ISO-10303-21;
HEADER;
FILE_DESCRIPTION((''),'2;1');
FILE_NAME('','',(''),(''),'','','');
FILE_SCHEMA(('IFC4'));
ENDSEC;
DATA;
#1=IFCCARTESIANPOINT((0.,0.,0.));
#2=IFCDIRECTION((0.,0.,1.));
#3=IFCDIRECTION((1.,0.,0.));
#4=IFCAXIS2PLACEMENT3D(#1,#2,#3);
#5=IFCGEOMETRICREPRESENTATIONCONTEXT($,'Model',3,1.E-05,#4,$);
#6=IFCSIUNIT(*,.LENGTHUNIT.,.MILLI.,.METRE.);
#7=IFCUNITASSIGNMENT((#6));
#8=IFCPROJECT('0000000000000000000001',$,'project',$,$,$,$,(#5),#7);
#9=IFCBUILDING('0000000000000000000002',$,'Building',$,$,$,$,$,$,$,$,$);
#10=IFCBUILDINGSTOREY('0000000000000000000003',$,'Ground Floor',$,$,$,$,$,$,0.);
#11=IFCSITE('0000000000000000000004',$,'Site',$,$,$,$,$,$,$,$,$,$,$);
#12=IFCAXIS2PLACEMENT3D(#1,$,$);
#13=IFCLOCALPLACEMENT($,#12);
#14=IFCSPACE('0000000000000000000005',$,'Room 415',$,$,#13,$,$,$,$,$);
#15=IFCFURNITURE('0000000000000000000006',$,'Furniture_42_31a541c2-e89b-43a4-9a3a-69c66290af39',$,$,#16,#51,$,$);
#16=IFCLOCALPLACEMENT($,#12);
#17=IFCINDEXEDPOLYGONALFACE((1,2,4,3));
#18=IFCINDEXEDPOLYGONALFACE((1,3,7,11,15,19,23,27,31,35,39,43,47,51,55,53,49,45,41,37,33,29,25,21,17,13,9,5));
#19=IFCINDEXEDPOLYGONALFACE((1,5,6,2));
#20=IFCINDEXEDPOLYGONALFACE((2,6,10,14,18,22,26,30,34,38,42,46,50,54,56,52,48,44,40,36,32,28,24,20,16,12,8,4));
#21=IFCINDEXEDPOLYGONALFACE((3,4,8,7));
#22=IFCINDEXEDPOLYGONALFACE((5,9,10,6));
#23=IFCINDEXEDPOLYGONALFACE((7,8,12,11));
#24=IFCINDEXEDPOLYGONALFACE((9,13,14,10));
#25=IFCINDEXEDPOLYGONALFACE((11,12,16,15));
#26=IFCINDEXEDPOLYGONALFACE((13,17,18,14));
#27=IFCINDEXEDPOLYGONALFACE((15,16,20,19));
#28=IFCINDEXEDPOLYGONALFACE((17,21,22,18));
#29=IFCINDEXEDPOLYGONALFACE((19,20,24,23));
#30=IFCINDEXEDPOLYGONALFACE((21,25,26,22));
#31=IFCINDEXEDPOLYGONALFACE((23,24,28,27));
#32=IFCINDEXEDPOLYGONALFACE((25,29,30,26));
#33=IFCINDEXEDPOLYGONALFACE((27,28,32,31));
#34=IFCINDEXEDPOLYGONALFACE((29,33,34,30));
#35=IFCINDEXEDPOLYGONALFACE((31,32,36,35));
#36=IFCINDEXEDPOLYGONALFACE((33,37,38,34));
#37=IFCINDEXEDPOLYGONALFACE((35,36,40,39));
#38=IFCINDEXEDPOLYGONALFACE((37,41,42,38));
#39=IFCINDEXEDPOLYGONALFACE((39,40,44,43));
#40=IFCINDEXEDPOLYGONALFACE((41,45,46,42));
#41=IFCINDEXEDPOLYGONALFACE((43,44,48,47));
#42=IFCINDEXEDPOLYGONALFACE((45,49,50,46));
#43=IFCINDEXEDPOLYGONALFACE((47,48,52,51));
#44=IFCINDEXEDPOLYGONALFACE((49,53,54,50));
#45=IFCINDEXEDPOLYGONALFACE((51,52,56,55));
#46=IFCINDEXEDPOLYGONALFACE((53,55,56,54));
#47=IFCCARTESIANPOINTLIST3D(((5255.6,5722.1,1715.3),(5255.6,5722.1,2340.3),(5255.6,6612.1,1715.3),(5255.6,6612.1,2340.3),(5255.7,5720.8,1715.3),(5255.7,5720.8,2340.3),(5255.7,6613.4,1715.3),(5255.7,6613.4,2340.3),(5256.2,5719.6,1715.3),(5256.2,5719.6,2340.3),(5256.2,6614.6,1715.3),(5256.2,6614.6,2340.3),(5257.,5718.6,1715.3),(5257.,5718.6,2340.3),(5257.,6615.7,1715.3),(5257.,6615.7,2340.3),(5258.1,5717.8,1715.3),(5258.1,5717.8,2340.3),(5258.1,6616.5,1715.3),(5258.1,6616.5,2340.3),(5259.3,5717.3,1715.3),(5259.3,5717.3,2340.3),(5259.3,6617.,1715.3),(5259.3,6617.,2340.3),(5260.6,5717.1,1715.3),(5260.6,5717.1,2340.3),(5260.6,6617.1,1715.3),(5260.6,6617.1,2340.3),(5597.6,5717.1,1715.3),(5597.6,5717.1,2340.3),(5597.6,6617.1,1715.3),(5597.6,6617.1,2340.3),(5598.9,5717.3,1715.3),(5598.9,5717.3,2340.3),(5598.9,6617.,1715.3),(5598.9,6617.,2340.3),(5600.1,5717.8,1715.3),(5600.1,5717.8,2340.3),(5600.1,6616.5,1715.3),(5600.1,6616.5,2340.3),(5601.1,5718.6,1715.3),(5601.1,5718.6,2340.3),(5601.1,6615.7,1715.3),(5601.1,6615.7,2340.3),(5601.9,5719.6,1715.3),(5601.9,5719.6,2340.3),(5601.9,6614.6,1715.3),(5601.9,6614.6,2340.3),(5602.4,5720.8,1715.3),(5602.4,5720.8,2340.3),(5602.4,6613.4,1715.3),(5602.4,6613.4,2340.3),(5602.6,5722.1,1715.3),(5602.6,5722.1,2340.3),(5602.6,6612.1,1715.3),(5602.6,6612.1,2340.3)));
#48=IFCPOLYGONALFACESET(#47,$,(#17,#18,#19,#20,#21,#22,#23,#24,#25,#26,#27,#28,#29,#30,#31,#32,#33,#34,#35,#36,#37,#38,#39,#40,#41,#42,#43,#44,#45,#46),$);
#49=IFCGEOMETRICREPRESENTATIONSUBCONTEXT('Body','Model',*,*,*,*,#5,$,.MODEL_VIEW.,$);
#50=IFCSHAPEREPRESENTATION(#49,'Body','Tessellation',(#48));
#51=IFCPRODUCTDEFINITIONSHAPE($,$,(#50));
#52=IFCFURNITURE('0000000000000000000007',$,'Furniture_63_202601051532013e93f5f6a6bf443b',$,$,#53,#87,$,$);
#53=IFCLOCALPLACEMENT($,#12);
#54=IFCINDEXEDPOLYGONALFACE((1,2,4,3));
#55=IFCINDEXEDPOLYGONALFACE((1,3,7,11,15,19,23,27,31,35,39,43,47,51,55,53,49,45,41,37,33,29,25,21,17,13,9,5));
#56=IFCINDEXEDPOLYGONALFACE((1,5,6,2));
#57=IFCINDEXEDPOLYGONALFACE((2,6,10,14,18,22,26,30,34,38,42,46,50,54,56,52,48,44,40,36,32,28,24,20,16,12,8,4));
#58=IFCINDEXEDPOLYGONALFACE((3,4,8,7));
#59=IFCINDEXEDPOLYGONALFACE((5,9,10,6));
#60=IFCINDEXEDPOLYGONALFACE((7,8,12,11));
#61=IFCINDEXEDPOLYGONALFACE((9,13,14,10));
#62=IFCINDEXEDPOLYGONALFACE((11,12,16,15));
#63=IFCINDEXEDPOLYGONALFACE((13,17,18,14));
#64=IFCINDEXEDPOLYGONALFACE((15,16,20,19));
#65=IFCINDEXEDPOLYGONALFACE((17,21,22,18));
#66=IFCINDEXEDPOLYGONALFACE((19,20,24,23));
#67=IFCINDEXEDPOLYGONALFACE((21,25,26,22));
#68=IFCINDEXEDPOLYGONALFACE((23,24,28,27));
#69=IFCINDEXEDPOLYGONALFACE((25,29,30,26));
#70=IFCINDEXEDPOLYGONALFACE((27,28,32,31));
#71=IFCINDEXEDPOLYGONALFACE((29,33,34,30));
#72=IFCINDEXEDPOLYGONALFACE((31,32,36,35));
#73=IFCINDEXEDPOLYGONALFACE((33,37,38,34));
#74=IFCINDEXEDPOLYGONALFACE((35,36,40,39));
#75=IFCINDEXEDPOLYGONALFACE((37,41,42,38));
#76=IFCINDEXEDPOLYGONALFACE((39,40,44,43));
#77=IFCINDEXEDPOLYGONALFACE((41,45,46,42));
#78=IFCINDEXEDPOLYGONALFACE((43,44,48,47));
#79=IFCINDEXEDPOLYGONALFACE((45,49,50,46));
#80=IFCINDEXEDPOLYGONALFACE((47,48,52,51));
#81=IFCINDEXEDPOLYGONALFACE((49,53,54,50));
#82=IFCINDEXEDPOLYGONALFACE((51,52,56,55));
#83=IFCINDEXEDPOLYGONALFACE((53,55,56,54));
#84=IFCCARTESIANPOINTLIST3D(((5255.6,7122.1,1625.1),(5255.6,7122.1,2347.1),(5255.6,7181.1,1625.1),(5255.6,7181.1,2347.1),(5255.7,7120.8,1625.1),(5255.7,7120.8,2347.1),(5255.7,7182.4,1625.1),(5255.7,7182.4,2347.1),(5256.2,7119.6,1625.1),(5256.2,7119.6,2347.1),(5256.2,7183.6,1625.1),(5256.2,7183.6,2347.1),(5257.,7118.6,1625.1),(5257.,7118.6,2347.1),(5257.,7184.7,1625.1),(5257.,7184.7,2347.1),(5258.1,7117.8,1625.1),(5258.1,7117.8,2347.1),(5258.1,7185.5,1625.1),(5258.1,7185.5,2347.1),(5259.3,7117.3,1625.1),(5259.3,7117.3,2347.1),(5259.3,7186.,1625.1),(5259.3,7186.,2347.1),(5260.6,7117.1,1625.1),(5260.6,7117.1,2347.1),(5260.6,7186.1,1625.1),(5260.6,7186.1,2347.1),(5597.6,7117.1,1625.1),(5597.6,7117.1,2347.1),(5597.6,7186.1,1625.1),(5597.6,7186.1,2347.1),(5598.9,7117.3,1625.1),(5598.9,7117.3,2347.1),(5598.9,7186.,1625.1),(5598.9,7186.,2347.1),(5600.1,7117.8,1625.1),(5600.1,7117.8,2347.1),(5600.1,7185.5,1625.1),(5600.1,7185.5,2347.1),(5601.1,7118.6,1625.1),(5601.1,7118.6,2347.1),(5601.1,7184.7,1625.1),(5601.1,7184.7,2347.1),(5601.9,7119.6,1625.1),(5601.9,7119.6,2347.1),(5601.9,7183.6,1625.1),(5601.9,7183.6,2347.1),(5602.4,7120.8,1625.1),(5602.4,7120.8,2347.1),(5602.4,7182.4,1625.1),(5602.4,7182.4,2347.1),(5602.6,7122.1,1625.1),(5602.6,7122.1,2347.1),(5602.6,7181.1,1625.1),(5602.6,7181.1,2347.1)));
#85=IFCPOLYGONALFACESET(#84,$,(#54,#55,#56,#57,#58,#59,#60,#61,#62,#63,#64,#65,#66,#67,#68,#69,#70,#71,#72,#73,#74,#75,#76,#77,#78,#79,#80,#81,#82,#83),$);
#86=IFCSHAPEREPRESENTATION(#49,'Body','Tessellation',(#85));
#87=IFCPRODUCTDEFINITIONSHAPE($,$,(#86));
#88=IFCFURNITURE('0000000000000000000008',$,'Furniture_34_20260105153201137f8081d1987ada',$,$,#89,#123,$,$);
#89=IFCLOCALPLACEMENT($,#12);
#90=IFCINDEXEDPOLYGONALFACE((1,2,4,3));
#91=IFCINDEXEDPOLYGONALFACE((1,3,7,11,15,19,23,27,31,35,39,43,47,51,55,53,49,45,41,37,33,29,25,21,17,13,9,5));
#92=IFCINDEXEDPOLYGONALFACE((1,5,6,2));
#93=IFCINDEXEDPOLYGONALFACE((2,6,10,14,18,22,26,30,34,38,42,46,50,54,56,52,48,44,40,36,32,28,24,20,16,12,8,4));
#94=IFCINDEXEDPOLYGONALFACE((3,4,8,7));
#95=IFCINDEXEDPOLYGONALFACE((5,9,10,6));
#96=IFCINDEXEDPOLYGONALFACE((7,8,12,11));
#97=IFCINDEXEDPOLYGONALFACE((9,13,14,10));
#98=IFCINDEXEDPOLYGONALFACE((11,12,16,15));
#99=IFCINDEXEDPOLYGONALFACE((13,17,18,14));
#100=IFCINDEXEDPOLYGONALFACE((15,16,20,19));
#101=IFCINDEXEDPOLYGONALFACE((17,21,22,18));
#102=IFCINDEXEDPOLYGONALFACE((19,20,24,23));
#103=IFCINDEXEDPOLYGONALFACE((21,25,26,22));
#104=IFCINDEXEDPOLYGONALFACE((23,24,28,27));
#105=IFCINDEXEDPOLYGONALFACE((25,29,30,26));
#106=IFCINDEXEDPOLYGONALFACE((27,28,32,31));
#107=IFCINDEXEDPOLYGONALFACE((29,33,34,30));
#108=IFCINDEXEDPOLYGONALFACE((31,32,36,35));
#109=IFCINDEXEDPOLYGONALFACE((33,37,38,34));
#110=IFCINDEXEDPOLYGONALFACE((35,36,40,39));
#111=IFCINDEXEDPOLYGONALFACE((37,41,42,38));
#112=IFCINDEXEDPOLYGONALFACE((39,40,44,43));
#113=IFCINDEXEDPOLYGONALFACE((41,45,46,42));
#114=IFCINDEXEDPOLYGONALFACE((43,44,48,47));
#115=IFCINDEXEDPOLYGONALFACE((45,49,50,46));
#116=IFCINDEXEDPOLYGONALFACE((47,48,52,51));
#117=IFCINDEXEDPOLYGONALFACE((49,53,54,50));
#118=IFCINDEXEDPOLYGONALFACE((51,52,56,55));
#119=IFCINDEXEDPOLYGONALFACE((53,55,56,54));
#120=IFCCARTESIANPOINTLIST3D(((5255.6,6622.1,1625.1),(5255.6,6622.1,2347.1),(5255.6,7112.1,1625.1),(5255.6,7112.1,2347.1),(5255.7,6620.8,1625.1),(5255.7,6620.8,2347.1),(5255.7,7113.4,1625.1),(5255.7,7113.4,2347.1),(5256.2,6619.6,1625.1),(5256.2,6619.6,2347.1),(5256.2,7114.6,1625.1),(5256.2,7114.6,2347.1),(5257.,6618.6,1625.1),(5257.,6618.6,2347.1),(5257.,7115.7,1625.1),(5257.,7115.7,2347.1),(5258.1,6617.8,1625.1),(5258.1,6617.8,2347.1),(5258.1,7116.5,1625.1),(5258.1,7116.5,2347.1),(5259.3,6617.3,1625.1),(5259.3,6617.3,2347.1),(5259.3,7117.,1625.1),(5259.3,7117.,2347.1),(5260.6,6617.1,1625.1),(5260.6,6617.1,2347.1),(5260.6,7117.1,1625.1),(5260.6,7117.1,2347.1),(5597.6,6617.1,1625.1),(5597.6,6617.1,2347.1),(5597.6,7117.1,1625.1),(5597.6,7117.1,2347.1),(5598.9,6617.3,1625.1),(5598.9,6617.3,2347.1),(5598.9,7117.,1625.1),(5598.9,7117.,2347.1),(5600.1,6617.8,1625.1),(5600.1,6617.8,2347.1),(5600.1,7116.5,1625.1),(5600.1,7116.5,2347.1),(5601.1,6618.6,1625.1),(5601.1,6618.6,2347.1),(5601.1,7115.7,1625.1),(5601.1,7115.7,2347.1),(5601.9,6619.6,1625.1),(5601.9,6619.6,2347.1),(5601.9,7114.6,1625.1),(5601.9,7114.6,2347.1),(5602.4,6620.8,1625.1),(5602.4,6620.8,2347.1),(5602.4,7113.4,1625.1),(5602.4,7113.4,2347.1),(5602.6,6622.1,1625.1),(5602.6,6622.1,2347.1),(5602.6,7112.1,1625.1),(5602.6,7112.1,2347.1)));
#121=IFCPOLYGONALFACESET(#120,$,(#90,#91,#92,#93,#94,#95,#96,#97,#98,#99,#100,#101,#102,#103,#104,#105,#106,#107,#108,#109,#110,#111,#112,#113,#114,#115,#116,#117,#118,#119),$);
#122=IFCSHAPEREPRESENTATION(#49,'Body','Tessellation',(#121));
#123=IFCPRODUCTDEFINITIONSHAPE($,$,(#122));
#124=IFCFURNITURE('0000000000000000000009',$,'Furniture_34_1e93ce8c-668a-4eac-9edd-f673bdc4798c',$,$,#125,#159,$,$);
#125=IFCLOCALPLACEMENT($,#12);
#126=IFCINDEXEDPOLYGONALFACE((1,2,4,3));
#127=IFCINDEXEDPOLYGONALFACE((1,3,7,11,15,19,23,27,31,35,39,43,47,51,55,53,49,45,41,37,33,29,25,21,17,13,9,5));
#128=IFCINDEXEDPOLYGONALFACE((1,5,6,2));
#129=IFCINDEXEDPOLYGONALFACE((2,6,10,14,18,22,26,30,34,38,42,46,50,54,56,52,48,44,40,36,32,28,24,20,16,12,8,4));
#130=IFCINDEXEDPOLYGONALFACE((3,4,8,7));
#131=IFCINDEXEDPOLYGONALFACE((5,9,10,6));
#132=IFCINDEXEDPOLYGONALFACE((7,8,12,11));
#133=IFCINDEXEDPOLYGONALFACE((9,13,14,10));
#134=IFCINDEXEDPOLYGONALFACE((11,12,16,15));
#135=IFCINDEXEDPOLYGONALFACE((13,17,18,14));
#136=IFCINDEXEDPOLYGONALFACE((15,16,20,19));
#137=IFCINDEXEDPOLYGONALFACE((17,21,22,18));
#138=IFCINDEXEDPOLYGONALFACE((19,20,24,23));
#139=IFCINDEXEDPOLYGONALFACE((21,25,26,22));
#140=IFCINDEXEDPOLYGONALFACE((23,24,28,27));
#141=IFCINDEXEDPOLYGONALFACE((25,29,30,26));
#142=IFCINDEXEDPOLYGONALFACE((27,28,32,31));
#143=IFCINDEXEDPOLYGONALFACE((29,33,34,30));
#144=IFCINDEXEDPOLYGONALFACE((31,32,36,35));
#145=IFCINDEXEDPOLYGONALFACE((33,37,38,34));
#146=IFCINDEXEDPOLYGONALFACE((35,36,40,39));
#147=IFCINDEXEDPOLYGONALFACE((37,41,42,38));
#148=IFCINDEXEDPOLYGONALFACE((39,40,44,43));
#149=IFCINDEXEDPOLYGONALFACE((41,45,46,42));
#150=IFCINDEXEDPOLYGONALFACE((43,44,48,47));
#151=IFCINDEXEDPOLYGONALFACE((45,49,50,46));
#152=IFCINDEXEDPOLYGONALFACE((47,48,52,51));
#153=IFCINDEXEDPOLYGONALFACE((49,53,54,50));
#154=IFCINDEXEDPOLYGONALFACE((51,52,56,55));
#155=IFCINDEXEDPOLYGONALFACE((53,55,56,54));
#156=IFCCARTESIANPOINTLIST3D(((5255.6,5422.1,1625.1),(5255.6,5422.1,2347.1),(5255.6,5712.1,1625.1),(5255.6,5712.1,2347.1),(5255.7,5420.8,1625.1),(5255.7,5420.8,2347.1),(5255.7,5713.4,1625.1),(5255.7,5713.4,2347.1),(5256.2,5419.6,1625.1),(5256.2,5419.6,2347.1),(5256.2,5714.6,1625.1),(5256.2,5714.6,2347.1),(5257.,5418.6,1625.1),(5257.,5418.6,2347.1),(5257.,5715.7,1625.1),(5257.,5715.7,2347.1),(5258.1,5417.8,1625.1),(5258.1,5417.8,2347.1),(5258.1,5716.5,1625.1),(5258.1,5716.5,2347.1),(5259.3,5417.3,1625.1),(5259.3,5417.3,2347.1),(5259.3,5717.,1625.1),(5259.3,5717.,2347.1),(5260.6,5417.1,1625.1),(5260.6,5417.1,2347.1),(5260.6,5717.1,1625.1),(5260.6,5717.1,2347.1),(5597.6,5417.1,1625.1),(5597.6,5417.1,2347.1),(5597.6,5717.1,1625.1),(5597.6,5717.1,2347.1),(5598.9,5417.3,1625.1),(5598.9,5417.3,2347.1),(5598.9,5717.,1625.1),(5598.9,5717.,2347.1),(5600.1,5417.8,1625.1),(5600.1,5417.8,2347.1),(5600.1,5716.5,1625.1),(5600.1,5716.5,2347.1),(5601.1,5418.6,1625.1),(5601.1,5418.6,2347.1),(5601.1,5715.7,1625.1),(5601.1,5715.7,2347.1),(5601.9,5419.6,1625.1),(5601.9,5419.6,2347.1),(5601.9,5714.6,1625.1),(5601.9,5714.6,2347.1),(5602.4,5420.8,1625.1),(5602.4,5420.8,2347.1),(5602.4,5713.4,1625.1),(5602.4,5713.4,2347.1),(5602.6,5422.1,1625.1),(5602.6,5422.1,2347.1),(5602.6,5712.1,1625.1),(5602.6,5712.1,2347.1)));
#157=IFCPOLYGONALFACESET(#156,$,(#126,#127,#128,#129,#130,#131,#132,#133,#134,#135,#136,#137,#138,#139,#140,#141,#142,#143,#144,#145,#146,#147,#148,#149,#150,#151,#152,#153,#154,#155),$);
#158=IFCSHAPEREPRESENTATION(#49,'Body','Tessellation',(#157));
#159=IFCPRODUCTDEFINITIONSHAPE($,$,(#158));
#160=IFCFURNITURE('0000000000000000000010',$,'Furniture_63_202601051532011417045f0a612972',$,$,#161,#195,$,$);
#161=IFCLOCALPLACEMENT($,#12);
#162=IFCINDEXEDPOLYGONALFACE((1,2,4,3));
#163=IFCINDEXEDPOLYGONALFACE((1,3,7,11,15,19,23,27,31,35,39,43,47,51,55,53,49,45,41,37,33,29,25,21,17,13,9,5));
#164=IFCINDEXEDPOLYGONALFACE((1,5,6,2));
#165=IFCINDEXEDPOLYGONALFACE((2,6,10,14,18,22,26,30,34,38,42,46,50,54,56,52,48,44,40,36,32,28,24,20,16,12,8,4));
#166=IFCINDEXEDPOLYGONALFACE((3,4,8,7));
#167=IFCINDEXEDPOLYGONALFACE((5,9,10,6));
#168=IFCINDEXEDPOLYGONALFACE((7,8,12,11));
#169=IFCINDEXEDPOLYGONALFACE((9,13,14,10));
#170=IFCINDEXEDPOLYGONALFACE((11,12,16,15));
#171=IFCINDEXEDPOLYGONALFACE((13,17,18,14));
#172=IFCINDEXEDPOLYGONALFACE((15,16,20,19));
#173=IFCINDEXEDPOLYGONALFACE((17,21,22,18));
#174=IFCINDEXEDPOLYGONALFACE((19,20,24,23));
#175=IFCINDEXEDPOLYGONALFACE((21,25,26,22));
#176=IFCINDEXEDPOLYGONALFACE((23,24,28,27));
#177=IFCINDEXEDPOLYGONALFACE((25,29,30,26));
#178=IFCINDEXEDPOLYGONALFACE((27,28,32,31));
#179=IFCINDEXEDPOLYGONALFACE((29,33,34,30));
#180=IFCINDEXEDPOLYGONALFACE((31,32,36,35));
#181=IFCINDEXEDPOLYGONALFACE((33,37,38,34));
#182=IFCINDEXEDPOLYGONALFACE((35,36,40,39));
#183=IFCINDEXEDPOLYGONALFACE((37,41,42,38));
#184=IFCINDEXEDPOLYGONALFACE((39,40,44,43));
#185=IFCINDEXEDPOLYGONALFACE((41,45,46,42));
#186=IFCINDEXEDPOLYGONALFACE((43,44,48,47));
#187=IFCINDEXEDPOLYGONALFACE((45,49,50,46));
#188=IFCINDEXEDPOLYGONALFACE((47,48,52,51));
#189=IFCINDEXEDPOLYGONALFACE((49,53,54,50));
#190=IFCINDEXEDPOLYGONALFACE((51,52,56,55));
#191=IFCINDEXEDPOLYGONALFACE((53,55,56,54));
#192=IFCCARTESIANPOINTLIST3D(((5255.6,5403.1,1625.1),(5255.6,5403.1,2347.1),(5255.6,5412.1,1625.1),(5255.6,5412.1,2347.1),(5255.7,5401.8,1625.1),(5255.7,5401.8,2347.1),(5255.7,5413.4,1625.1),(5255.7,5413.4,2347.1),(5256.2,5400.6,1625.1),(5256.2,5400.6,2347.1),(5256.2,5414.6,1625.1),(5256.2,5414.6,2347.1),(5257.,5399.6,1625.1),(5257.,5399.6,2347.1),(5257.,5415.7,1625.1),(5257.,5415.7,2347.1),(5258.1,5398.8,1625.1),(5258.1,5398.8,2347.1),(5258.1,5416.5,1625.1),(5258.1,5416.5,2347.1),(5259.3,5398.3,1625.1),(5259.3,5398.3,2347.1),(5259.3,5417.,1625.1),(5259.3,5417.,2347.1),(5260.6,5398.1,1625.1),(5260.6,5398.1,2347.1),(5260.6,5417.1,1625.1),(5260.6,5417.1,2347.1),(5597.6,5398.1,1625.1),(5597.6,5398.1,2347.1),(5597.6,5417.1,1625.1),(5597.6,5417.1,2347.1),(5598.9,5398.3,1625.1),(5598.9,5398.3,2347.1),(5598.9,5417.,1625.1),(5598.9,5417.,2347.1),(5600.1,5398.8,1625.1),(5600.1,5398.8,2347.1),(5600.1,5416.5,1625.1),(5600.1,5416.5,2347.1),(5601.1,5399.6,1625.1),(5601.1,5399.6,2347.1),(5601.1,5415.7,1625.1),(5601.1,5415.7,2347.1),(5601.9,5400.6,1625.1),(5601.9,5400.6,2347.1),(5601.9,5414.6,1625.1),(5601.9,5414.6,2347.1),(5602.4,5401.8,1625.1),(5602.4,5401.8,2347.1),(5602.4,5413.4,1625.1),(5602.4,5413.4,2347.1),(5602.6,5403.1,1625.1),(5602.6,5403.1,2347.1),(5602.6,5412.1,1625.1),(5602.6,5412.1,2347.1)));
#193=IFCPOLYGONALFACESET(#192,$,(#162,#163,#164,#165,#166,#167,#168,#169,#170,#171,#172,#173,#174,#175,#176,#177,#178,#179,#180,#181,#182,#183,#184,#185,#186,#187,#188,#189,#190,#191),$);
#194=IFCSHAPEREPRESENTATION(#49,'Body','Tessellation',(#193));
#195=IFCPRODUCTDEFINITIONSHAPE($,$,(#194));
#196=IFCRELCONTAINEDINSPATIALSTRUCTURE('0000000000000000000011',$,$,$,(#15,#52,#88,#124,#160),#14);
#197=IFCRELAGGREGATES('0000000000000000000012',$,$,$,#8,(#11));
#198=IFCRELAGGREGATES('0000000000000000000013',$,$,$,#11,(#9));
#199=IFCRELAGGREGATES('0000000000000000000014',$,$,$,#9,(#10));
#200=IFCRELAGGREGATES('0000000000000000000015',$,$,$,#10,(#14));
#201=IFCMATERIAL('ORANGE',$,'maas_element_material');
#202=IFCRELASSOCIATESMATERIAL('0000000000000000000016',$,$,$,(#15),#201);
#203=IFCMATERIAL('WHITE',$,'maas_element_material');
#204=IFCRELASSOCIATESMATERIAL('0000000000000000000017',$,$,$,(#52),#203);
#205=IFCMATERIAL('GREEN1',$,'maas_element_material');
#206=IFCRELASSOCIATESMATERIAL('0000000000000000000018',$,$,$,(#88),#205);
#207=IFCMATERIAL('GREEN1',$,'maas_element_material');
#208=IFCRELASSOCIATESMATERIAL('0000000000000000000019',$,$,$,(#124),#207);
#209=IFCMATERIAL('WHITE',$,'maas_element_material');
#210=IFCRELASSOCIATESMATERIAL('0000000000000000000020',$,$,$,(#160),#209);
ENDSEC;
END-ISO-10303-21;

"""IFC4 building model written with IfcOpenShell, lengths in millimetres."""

from ifc_helpers import new_model, si_unit, frame, origin, origin_with_axes, place, context, subcontext, project, spatial, rounded_rectangle, extrude, material, element, save


model = new_model("IFC4")

# Units and contexts
model_context = context("Model", 3, precision=1e-05, world=origin_with_axes())
body_context = subcontext(model_context, "Body", "Model", "MODEL_VIEW")
ifc_project = project(units=[si_unit("LENGTHUNIT", "METRE", prefix="MILLI")], contexts=[model_context])

# Site, building, storey, space
site = spatial("IfcSite", under=ifc_project, Name="Site")
building = spatial("IfcBuilding", under=site, Name="Building")
storey = spatial("IfcBuildingStorey", under=building, Name="Ground Floor", Elevation=0.0)
space_placement = place(None, origin())
space = spatial("IfcSpace", under=storey, at=space_placement, Name="Room 415")

# Furniture
ifc_material_1 = material(Name="ORANGE", Category="maas_element_material")
furniture_1_placement = place(space_placement, frame((5429.1, 6167.1, 2027.8), z_axis=(0.0, 0.0, 1.0), x_axis=(0.000001, -1.0, 0.0)))
element("IfcFurniture", 1, at=furniture_1_placement, inside=space, material=ifc_material_1, Name="Furniture_42_31a541c2-e89b-43a4-9a3a-69c66290af39", context=body_context, shape_type="SweptSolid", body=[
    extrude(rounded_rectangle(XDim=900.0, YDim=347.0, RoundingRadius=5.0), frame((0.0, 0.0, -312.5), z_axis=(0.0, 0.0, 1.0), x_axis=(1.0, 0.0, 0.0)), (0.0, 0.0, 1.0), 625.0),
])
ifc_material_2 = material(Name="WHITE", Category="maas_element_material")
furniture_2_placement = place(space_placement, frame((5429.1, 7151.6, 1986.1), z_axis=(0.0, 0.0, 1.0), x_axis=(0.000001, -1.0, 0.0)))
element("IfcFurniture", 2, at=furniture_2_placement, inside=space, material=ifc_material_2, Name="Furniture_63_202601051532013e93f5f6a6bf443b", context=body_context, shape_type="SweptSolid", body=[
    extrude(rounded_rectangle(XDim=69.0, YDim=347.0, RoundingRadius=5.0), frame((0.0, 0.0, -361.0), z_axis=(0.0, 0.0, 1.0), x_axis=(1.0, 0.0, 0.0)), (0.0, 0.0, 1.0), 722.0),
])
ifc_material_3 = material(Name="GREEN1", Category="maas_element_material")
furniture_3_placement = place(space_placement, frame((5429.1, 6867.1, 1986.1), z_axis=(0.0, 0.0, 1.0), x_axis=(0.000001, -1.0, 0.0)))
element("IfcFurniture", 3, at=furniture_3_placement, inside=space, material=ifc_material_3, Name="Furniture_34_20260105153201137f8081d1987ada", context=body_context, shape_type="SweptSolid", body=[
    extrude(rounded_rectangle(XDim=500.0, YDim=347.0, RoundingRadius=5.0), frame((0.0, 0.0, -361.0), z_axis=(0.0, 0.0, 1.0), x_axis=(1.0, 0.0, 0.0)), (0.0, 0.0, 1.0), 722.0),
])
ifc_material_4 = material(Name="GREEN1", Category="maas_element_material")
furniture_4_placement = place(space_placement, frame((5429.1, 5567.1, 1986.1), z_axis=(0.0, 0.0, 1.0), x_axis=(0.000001, -1.0, 0.0)))
element("IfcFurniture", 4, at=furniture_4_placement, inside=space, material=ifc_material_4, Name="Furniture_34_1e93ce8c-668a-4eac-9edd-f673bdc4798c", context=body_context, shape_type="SweptSolid", body=[
    extrude(rounded_rectangle(XDim=300.0, YDim=347.0, RoundingRadius=5.0), frame((0.0, 0.0, -361.0), z_axis=(0.0, 0.0, 1.0), x_axis=(1.0, 0.0, 0.0)), (0.0, 0.0, 1.0), 722.0),
])
ifc_material_5 = material(Name="WHITE", Category="maas_element_material")
furniture_5_placement = place(space_placement, frame((5429.1, 5407.6, 1986.1), z_axis=(0.0, 0.0, 1.0), x_axis=(0.000001, -1.0, 0.0)))
element("IfcFurniture", 5, at=furniture_5_placement, inside=space, material=ifc_material_5, Name="Furniture_63_202601051532011417045f0a612972", context=body_context, shape_type="SweptSolid", body=[
    extrude(rounded_rectangle(XDim=19.0, YDim=347.0, RoundingRadius=5.0), frame((0.0, 0.0, -361.0), z_axis=(0.0, 0.0, 1.0), x_axis=(1.0, 0.0, 0.0)), (0.0, 0.0, 1.0), 722.0),
])

save(model, "model.ifc")
